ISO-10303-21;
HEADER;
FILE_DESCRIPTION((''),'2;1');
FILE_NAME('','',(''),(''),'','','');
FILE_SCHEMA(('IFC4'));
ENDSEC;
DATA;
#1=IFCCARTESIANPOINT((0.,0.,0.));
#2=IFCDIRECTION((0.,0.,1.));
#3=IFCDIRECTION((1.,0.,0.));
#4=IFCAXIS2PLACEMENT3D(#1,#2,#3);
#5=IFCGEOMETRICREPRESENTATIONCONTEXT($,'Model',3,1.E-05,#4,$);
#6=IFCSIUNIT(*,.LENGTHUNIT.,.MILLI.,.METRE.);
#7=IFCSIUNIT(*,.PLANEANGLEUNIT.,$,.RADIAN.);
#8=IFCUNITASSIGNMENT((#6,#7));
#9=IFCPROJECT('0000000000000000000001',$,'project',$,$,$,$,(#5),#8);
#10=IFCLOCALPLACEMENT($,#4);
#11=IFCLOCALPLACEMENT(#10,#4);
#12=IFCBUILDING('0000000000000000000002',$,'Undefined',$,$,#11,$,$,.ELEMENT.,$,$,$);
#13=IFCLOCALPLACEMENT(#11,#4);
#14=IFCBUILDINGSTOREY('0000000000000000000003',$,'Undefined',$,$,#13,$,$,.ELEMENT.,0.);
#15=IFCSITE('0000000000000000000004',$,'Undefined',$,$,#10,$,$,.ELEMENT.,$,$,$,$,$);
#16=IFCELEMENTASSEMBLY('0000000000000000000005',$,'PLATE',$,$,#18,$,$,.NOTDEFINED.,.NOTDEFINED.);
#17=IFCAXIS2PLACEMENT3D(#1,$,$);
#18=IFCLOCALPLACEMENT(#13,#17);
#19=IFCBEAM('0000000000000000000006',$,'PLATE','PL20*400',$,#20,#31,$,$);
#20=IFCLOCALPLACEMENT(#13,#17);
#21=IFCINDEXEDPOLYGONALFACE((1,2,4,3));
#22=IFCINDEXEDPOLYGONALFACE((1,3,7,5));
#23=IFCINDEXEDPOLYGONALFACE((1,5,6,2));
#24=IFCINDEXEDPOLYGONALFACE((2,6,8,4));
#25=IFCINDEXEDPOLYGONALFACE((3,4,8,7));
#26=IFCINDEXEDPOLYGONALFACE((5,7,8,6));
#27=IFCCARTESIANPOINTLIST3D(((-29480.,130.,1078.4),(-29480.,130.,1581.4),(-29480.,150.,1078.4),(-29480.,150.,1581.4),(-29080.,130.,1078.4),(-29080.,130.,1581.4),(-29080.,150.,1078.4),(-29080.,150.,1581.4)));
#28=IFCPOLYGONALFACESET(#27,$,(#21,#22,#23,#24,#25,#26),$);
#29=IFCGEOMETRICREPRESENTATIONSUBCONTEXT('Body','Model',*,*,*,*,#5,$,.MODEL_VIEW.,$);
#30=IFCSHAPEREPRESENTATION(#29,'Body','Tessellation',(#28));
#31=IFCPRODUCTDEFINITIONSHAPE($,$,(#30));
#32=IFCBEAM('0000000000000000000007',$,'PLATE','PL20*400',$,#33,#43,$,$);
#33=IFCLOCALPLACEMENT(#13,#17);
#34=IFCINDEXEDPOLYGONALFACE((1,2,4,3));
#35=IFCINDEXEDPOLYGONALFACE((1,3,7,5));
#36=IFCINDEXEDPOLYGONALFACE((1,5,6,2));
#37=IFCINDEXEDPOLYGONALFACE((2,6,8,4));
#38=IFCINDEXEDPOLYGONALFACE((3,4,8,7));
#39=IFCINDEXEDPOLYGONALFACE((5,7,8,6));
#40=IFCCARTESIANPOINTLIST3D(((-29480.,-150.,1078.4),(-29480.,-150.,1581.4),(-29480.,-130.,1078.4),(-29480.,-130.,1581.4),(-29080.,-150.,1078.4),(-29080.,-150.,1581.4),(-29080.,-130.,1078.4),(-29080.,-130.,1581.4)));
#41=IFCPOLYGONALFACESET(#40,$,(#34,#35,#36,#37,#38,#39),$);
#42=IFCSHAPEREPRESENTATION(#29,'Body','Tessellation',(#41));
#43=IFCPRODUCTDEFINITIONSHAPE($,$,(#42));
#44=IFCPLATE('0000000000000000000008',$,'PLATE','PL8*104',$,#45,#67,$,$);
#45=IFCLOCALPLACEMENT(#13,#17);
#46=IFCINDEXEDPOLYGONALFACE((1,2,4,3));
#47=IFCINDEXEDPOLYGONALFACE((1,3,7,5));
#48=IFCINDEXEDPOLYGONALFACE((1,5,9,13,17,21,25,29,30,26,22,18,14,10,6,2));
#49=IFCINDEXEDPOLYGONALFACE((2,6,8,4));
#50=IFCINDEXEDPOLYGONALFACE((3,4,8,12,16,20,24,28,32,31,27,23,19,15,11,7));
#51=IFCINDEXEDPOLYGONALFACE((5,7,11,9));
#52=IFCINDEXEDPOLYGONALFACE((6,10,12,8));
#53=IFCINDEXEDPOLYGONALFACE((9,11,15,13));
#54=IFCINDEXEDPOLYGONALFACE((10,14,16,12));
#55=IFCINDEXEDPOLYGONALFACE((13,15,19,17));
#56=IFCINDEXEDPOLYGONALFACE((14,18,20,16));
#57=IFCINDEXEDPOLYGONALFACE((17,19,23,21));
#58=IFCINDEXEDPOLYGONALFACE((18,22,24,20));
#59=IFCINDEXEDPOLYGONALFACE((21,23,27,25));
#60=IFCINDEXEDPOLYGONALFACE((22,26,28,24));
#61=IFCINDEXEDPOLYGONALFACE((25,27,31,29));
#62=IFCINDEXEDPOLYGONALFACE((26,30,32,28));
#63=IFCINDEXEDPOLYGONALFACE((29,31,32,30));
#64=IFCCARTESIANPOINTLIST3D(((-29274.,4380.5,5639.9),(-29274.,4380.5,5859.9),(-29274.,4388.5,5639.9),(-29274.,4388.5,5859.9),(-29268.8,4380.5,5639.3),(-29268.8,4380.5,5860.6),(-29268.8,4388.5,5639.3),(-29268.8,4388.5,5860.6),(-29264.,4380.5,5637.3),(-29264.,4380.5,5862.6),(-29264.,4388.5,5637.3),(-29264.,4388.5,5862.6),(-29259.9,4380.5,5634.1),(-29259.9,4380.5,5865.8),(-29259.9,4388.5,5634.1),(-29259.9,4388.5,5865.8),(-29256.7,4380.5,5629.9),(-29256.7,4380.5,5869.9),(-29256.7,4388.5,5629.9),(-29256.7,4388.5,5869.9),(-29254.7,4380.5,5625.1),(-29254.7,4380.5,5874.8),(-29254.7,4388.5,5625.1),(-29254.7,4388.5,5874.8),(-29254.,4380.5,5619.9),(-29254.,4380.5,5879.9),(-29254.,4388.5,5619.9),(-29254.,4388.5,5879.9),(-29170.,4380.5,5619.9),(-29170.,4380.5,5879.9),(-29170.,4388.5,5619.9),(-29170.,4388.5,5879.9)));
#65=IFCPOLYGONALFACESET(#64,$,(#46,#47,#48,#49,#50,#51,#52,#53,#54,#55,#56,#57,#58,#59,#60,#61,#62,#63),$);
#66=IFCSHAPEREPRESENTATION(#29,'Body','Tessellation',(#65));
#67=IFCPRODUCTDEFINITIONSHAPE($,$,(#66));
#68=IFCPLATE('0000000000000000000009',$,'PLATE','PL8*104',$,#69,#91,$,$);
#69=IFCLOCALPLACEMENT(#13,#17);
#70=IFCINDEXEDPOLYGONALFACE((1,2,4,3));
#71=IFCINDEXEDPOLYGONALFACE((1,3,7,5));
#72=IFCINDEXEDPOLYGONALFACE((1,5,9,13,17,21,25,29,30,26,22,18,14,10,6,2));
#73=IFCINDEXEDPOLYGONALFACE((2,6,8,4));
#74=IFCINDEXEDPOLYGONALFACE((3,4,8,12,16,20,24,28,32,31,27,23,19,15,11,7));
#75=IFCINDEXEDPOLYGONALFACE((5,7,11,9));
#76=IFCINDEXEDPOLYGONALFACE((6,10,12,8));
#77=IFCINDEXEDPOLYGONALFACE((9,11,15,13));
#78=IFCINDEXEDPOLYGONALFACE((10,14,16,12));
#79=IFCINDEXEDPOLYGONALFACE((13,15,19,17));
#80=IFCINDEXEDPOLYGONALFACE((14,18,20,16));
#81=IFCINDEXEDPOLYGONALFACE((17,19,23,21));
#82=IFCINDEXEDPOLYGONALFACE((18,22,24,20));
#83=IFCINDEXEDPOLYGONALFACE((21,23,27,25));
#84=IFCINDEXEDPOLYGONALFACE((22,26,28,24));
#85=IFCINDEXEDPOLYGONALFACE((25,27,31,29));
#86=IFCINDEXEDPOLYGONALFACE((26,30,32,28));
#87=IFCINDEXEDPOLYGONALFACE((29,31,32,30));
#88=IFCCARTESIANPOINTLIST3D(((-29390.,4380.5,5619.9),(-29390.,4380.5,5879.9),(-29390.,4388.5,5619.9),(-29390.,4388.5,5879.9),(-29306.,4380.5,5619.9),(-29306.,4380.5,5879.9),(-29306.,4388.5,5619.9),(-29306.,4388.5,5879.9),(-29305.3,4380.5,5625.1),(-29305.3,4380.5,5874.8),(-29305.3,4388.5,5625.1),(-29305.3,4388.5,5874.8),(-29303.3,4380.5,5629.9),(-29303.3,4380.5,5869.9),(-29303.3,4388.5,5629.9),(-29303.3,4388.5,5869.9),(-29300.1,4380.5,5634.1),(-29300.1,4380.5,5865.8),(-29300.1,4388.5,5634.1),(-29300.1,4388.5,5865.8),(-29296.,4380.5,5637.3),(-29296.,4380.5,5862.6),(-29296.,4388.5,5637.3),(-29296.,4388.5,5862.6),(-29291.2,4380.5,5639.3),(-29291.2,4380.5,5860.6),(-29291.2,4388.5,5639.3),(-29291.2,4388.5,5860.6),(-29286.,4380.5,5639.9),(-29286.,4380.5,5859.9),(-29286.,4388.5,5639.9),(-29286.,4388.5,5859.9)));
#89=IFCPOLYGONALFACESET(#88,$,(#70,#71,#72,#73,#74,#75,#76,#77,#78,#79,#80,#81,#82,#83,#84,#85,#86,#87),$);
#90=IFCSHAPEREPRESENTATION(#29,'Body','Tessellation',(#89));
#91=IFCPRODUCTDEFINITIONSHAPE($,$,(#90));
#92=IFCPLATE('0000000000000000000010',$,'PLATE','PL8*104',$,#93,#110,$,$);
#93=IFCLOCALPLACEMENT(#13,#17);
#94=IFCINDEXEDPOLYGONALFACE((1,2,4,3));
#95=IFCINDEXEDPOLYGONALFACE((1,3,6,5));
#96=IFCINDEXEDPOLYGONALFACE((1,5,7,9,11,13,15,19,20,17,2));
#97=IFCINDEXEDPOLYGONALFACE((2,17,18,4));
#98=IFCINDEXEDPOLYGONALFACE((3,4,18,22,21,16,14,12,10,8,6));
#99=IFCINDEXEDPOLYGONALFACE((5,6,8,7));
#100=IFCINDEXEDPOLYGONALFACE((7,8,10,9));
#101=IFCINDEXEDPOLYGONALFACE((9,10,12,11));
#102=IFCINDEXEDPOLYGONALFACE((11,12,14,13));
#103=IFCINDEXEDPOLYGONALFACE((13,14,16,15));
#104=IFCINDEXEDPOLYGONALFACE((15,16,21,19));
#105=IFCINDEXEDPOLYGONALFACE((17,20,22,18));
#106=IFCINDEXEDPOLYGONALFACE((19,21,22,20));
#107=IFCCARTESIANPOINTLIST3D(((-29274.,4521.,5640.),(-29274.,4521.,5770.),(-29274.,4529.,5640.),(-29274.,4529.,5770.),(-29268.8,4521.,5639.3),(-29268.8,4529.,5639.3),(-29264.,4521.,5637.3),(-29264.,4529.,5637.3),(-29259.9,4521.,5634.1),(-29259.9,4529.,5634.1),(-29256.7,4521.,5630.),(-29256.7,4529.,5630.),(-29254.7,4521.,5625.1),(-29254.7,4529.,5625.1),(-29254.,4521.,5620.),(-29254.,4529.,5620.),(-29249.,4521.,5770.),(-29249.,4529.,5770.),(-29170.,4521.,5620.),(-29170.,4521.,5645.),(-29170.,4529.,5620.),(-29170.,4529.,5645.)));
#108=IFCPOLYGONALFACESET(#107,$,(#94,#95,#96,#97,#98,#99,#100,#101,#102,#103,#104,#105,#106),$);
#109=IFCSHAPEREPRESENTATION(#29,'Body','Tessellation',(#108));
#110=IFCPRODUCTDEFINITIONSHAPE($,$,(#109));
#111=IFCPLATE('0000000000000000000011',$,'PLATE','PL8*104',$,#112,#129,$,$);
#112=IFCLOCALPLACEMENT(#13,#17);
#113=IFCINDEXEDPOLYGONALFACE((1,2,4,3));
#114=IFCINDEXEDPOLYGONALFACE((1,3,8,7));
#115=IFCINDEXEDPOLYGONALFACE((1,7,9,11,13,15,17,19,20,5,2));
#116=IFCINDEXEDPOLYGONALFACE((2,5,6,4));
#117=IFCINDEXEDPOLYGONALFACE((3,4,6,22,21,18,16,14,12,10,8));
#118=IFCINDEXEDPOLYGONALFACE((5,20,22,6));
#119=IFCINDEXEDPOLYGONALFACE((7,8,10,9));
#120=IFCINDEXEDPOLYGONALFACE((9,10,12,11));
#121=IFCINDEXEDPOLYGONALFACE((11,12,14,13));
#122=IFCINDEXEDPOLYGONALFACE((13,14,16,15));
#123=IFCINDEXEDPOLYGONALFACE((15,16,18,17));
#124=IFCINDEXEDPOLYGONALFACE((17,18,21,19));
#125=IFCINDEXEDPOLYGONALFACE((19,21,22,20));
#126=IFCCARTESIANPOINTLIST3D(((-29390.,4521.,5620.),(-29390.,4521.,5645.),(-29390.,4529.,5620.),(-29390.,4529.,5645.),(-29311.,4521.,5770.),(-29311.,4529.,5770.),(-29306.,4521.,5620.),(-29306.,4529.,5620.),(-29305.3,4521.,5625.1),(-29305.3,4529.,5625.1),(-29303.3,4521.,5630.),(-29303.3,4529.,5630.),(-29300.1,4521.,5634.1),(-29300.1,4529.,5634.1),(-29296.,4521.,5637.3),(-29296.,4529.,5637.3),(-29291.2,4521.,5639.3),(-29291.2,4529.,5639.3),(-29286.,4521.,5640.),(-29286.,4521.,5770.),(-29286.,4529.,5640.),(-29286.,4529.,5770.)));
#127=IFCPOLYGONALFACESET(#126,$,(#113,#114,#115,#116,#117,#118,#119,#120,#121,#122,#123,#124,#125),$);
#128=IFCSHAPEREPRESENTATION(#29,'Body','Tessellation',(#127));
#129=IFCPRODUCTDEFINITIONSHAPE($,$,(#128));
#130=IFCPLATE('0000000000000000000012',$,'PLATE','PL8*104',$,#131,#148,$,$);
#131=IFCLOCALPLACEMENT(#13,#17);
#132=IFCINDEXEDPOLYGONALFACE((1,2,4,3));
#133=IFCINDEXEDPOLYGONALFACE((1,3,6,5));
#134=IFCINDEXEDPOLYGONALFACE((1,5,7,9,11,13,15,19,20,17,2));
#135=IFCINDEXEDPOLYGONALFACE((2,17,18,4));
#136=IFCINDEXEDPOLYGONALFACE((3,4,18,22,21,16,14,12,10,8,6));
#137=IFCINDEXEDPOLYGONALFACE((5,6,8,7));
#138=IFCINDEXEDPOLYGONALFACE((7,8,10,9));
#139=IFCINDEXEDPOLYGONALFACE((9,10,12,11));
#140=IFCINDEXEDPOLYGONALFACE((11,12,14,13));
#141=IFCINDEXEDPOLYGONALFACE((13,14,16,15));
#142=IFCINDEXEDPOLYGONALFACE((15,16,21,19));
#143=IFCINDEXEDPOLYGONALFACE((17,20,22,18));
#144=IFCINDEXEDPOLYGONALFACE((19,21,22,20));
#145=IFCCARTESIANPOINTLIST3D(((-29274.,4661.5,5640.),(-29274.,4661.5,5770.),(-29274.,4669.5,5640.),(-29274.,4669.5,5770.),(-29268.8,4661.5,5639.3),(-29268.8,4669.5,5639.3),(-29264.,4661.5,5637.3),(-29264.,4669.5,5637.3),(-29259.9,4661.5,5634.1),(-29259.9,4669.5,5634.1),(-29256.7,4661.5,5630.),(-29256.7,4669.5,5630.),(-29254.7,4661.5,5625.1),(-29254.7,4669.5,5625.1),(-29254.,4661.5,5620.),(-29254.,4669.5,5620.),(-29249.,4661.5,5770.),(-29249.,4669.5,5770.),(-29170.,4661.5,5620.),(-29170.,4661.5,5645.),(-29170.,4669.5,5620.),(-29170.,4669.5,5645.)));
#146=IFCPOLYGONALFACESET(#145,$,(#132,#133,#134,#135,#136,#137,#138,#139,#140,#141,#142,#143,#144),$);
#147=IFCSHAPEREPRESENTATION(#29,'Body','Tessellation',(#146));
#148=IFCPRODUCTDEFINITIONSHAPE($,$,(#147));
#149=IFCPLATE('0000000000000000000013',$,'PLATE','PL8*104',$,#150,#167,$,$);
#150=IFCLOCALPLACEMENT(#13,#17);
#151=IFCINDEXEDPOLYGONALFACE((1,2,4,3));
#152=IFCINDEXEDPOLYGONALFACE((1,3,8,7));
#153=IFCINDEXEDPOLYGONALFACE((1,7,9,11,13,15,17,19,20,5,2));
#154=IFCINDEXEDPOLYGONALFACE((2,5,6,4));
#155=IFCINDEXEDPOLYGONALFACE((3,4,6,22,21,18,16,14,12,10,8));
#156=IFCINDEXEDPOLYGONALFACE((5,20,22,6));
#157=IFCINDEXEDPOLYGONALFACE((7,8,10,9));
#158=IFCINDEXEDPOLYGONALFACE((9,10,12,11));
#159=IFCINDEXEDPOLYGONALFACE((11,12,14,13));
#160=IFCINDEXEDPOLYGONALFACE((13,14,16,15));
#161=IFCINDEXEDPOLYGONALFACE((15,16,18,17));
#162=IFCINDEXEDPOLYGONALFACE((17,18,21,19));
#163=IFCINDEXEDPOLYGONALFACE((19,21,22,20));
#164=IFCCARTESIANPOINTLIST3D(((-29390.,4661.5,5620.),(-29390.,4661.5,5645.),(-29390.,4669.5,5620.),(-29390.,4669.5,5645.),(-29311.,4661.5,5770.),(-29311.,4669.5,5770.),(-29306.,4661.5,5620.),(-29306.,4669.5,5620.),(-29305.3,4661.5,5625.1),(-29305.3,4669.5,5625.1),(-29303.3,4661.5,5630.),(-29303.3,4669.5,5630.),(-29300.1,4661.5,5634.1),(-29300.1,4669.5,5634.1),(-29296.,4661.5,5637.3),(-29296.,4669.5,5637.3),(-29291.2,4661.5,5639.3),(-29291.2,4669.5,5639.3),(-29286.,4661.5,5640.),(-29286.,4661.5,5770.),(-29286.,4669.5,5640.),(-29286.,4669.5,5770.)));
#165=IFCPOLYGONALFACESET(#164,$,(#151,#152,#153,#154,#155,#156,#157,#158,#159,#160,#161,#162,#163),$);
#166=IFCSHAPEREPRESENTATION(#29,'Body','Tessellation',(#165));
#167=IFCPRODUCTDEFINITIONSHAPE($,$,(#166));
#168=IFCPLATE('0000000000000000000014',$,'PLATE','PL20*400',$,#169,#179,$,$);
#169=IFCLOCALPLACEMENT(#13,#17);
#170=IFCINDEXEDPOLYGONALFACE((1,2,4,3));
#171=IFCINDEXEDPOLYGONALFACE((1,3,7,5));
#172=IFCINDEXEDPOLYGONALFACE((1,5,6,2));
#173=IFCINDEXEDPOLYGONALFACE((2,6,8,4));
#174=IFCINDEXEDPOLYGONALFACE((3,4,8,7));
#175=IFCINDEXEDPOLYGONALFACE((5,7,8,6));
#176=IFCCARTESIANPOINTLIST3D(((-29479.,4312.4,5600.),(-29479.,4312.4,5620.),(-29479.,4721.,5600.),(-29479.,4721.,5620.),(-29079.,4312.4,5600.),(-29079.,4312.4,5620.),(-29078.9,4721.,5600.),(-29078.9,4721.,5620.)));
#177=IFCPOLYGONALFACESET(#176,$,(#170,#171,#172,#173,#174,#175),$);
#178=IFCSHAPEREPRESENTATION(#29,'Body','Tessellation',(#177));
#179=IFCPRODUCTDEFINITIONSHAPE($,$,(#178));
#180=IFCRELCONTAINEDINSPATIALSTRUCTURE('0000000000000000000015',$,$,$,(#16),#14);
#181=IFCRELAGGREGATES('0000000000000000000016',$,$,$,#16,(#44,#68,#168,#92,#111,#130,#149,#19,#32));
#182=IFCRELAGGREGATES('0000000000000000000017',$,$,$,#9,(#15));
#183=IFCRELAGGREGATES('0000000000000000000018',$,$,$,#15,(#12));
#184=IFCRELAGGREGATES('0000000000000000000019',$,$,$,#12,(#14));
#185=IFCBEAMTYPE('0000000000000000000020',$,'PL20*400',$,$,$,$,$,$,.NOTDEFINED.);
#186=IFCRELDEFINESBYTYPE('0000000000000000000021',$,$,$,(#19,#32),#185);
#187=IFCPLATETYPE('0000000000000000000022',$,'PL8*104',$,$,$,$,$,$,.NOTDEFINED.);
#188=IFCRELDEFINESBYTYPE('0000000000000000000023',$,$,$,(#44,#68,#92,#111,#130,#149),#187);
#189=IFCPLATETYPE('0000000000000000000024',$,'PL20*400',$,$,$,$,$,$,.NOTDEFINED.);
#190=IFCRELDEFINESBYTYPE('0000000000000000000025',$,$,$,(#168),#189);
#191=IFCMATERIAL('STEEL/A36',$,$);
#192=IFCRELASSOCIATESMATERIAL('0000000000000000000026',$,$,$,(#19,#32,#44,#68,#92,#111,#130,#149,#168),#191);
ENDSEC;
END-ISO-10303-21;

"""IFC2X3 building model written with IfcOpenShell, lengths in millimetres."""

from ifc_helpers import new_model, si_unit, frame, frame_2d, origin_with_axes, origin_2d_with_axis, place, context, subcontext, project, spatial, polyline, circle_curve, parameter, trimmed, segment, composite_curve, rectangle, outline, extrude, material, type_object, element, aggregate, save


model = new_model("IFC2X3")

# Units and contexts
model_context = context("Model", 3, precision=1e-05, world=origin_with_axes())
body_context = subcontext(model_context, "Body", "Model", "MODEL_VIEW")
ifc_project = project(units=[si_unit("LENGTHUNIT", "METRE", prefix="MILLI"), si_unit("PLANEANGLEUNIT", "RADIAN")], contexts=[model_context])

# Site, building, storey
site_placement = place(None, origin_with_axes())
site = spatial("IfcSite", under=ifc_project, at=site_placement, Name="Undefined", CompositionType="ELEMENT")
building_placement = place(site_placement, origin_with_axes())
building = spatial("IfcBuilding", under=site, at=building_placement, Name="Undefined", CompositionType="ELEMENT")
storey_placement = place(building_placement, origin_with_axes())
storey = spatial("IfcBuildingStorey", under=building, at=storey_placement, Name="Undefined", CompositionType="ELEMENT", Elevation=0.0)

# Element assembly, beams, plates
assembly_1_placement = place(storey_placement, origin_with_axes())
assembly_1 = element("IfcElementAssembly", 1, at=assembly_1_placement, inside=storey, Name="PLATE", AssemblyPlace="NOTDEFINED", PredefinedType="NOTDEFINED")
ifc_material_1 = material(Name="STEEL/A36")
beam_type_1 = type_object("IfcBeamType", Name="PL20*400", PredefinedType="NOTDEFINED")
beam_1_placement = place(assembly_1_placement, frame((-29280.0, 140.0, 1078.4), z_axis=(-1.0, 0.0, 0.0), x_axis=(0.0, 0.0, 1.0)))
beam_1 = element("IfcBeam", 2, at=beam_1_placement, type_object=beam_type_1, material=ifc_material_1, Name="PLATE", Description="PL20*400", context=body_context, shape_type="SweptSolid", body=[
    extrude(rectangle(XDim=20.0, YDim=400.0, at=origin_2d_with_axis()), frame((503.0, 0.0, 0.0), z_axis=(-1.0, 0.0, 0.0), x_axis=(0.0, -1.0, 0.0)), (0.0, 0.0, 1.0), 503.0),
])
beam_2_placement = place(assembly_1_placement, frame((-29280.0, -140.0, 1078.4), z_axis=(-1.0, 0.0, 0.0), x_axis=(0.0, 0.0, 1.0)))
beam_2 = element("IfcBeam", 3, at=beam_2_placement, type_object=beam_type_1, material=ifc_material_1, Name="PLATE", Description="PL20*400", context=body_context, shape_type="SweptSolid", body=[
    extrude(rectangle(XDim=20.0, YDim=400.0, at=origin_2d_with_axis()), frame((503.0, 0.0, 0.0), z_axis=(-1.0, 0.0, 0.0), x_axis=(0.0, -1.0, 0.0)), (0.0, 0.0, 1.0), 503.0),
])
plate_type_1 = type_object("IfcPlateType", Name="PL8*104", PredefinedType="NOTDEFINED")
plate_1_placement = place(assembly_1_placement, frame((-29170.0, 4384.5, 5879.9), z_axis=(0.0, 1.0, 0.0), x_axis=(0.0, 0.0, -1.0)))
plate_1 = element("IfcPlate", 4, at=plate_1_placement, type_object=plate_type_1, material=ifc_material_1, Name="PLATE", Description="PL8*104", context=body_context, shape_type="SweptSolid", body=[
    extrude(outline(composite_curve([segment(polyline([(0.0, 0.0), (260.0, 0.0), (260.0, 84.0)]), True, "CONTINUOUS"), segment(trimmed(circle_curve(frame_2d((260.0, 104.0), x_axis=(-0.000002, -1.0)), 20.0), [parameter(0.0)], [parameter(4.712391)], False, "PARAMETER"), True, "CONTINUOUS"), segment(polyline([(240.0, 104.0), (20.0, 104.0)]), True, "CONTINUOUS"), segment(trimmed(circle_curve(frame_2d((0.0, 104.0), x_axis=(1.0, 0.0)), 20.0), [parameter(0.0)], [parameter(4.712389)], False, "PARAMETER"), True, "CONTINUOUS"), segment(polyline([(0.0, 84.0), (0.0, 0.0)]), True, "CONTINUOUS")], self_intersect=True)), frame((0.0, 0.0, -4.0), z_axis=(0.0, 0.0, 1.0), x_axis=(1.0, 0.0, 0.0)), (0.0, 0.0, 1.0), 8.0),
])
plate_2_placement = place(assembly_1_placement, frame((-29390.0, 4384.5, 5879.9), z_axis=(0.0, -1.0, 0.0), x_axis=(0.0, 0.0, -1.0)))
plate_2 = element("IfcPlate", 5, at=plate_2_placement, type_object=plate_type_1, material=ifc_material_1, Name="PLATE", Description="PL8*104", context=body_context, shape_type="SweptSolid", body=[
    extrude(outline(composite_curve([segment(polyline([(0.0, 0.0), (260.0, 0.0), (260.0, 84.0)]), True, "CONTINUOUS"), segment(trimmed(circle_curve(frame_2d((260.0, 104.0), x_axis=(-0.000002, -1.0)), 20.0), [parameter(0.0)], [parameter(4.712391)], False, "PARAMETER"), True, "CONTINUOUS"), segment(polyline([(240.0, 104.0), (20.0, 104.0)]), True, "CONTINUOUS"), segment(trimmed(circle_curve(frame_2d((0.0, 104.0), x_axis=(1.0, 0.0)), 20.0), [parameter(0.0)], [parameter(4.712389)], False, "PARAMETER"), True, "CONTINUOUS"), segment(polyline([(0.0, 84.0), (0.0, 0.0)]), True, "CONTINUOUS")], self_intersect=True)), frame((0.0, 0.0, -4.0), z_axis=(0.0, 0.0, 1.0), x_axis=(1.0, 0.0, 0.0)), (0.0, 0.0, 1.0), 8.0),
])
plate_3_placement = place(assembly_1_placement, frame((-29274.0, 4525.0, 5620.0), z_axis=(0.0, 1.0, 0.0), x_axis=(0.0, 0.0, 1.0)))
plate_3 = element("IfcPlate", 6, at=plate_3_placement, type_object=plate_type_1, material=ifc_material_1, Name="PLATE", Description="PL8*104", context=body_context, shape_type="SweptSolid", body=[
    extrude(outline(composite_curve([segment(trimmed(circle_curve(frame_2d((0.0, 0.0), x_axis=(0.000147, 1.0)), 20.0), [parameter(0.0)], [parameter(4.712536)], False, "PARAMETER"), True, "CONTINUOUS"), segment(polyline([(20.0, 0.0), (150.0, 0.0), (150.0, 25.0), (25.0, 104.0), (0.0, 104.0), (0.0, 20.0)]), True, "CONTINUOUS")], self_intersect=True)), frame((0.0, 0.0, -4.0), z_axis=(0.0, 0.0, 1.0), x_axis=(1.0, 0.0, 0.0)), (0.0, 0.0, 1.0), 8.0),
])
plate_4_placement = place(assembly_1_placement, frame((-29286.0, 4525.0, 5620.0), z_axis=(0.0, -1.0, 0.0), x_axis=(0.0, 0.0, 1.0)))
plate_4 = element("IfcPlate", 7, at=plate_4_placement, type_object=plate_type_1, material=ifc_material_1, Name="PLATE", Description="PL8*104", context=body_context, shape_type="SweptSolid", body=[
    extrude(outline(composite_curve([segment(trimmed(circle_curve(frame_2d((0.0, 0.0), x_axis=(0.000147, 1.0)), 20.0), [parameter(0.0)], [parameter(4.712536)], False, "PARAMETER"), True, "CONTINUOUS"), segment(polyline([(20.0, 0.0), (150.0, 0.0), (150.0, 25.0), (25.0, 104.0), (0.0, 104.0), (0.0, 20.0)]), True, "CONTINUOUS")], self_intersect=True)), frame((0.0, 0.0, -4.0), z_axis=(0.0, 0.0, 1.0), x_axis=(1.0, 0.0, 0.0)), (0.0, 0.0, 1.0), 8.0),
])
plate_5_placement = place(assembly_1_placement, frame((-29274.0, 4665.5, 5620.0), z_axis=(0.0, 1.0, 0.0), x_axis=(0.0, 0.0, 1.0)))
plate_5 = element("IfcPlate", 8, at=plate_5_placement, type_object=plate_type_1, material=ifc_material_1, Name="PLATE", Description="PL8*104", context=body_context, shape_type="SweptSolid", body=[
    extrude(outline(composite_curve([segment(trimmed(circle_curve(frame_2d((0.0, 0.0), x_axis=(0.000147, 1.0)), 20.0), [parameter(0.0)], [parameter(4.712536)], False, "PARAMETER"), True, "CONTINUOUS"), segment(polyline([(20.0, 0.0), (150.0, 0.0), (150.0, 25.0), (25.0, 104.0), (0.0, 104.0), (0.0, 20.0)]), True, "CONTINUOUS")], self_intersect=True)), frame((0.0, 0.0, -4.0), z_axis=(0.0, 0.0, 1.0), x_axis=(1.0, 0.0, 0.0)), (0.0, 0.0, 1.0), 8.0),
])
plate_6_placement = place(assembly_1_placement, frame((-29286.0, 4665.5, 5620.0), z_axis=(0.0, -1.0, 0.0), x_axis=(0.0, 0.0, 1.0)))
plate_6 = element("IfcPlate", 9, at=plate_6_placement, type_object=plate_type_1, material=ifc_material_1, Name="PLATE", Description="PL8*104", context=body_context, shape_type="SweptSolid", body=[
    extrude(outline(composite_curve([segment(trimmed(circle_curve(frame_2d((0.0, 0.0), x_axis=(0.000147, 1.0)), 20.0), [parameter(0.0)], [parameter(4.712536)], False, "PARAMETER"), True, "CONTINUOUS"), segment(polyline([(20.0, 0.0), (150.0, 0.0), (150.0, 25.0), (25.0, 104.0), (0.0, 104.0), (0.0, 20.0)]), True, "CONTINUOUS")], self_intersect=True)), frame((0.0, 0.0, -4.0), z_axis=(0.0, 0.0, 1.0), x_axis=(1.0, 0.0, 0.0)), (0.0, 0.0, 1.0), 8.0),
])
plate_type_2 = type_object("IfcPlateType", Name="PL20*400", PredefinedType="NOTDEFINED")
plate_7_placement = place(assembly_1_placement, frame((-29078.9, 4721.0, 5610.0), z_axis=(0.0, 0.0, 1.0), x_axis=(-1.0, 0.0, 0.0)))
plate_7 = element("IfcPlate", 10, at=plate_7_placement, type_object=plate_type_2, material=ifc_material_1, Name="PLATE", Description="PL20*400", context=body_context, shape_type="SweptSolid", body=[
    extrude(outline(polyline([(0.0, 0.0), (400.1, 0.0), (400.1, 408.6), (0.1, 408.6), (0.0, 0.0)])), frame((0.0, 0.0, -10.0), z_axis=(0.0, 0.0, 1.0), x_axis=(1.0, 0.0, 0.0)), (0.0, 0.0, 1.0), 20.0),
])
aggregate(assembly_1, [plate_1, plate_2, plate_7, plate_3, plate_4, plate_5, plate_6, beam_1, beam_2])

save(model, "model.ifc")
